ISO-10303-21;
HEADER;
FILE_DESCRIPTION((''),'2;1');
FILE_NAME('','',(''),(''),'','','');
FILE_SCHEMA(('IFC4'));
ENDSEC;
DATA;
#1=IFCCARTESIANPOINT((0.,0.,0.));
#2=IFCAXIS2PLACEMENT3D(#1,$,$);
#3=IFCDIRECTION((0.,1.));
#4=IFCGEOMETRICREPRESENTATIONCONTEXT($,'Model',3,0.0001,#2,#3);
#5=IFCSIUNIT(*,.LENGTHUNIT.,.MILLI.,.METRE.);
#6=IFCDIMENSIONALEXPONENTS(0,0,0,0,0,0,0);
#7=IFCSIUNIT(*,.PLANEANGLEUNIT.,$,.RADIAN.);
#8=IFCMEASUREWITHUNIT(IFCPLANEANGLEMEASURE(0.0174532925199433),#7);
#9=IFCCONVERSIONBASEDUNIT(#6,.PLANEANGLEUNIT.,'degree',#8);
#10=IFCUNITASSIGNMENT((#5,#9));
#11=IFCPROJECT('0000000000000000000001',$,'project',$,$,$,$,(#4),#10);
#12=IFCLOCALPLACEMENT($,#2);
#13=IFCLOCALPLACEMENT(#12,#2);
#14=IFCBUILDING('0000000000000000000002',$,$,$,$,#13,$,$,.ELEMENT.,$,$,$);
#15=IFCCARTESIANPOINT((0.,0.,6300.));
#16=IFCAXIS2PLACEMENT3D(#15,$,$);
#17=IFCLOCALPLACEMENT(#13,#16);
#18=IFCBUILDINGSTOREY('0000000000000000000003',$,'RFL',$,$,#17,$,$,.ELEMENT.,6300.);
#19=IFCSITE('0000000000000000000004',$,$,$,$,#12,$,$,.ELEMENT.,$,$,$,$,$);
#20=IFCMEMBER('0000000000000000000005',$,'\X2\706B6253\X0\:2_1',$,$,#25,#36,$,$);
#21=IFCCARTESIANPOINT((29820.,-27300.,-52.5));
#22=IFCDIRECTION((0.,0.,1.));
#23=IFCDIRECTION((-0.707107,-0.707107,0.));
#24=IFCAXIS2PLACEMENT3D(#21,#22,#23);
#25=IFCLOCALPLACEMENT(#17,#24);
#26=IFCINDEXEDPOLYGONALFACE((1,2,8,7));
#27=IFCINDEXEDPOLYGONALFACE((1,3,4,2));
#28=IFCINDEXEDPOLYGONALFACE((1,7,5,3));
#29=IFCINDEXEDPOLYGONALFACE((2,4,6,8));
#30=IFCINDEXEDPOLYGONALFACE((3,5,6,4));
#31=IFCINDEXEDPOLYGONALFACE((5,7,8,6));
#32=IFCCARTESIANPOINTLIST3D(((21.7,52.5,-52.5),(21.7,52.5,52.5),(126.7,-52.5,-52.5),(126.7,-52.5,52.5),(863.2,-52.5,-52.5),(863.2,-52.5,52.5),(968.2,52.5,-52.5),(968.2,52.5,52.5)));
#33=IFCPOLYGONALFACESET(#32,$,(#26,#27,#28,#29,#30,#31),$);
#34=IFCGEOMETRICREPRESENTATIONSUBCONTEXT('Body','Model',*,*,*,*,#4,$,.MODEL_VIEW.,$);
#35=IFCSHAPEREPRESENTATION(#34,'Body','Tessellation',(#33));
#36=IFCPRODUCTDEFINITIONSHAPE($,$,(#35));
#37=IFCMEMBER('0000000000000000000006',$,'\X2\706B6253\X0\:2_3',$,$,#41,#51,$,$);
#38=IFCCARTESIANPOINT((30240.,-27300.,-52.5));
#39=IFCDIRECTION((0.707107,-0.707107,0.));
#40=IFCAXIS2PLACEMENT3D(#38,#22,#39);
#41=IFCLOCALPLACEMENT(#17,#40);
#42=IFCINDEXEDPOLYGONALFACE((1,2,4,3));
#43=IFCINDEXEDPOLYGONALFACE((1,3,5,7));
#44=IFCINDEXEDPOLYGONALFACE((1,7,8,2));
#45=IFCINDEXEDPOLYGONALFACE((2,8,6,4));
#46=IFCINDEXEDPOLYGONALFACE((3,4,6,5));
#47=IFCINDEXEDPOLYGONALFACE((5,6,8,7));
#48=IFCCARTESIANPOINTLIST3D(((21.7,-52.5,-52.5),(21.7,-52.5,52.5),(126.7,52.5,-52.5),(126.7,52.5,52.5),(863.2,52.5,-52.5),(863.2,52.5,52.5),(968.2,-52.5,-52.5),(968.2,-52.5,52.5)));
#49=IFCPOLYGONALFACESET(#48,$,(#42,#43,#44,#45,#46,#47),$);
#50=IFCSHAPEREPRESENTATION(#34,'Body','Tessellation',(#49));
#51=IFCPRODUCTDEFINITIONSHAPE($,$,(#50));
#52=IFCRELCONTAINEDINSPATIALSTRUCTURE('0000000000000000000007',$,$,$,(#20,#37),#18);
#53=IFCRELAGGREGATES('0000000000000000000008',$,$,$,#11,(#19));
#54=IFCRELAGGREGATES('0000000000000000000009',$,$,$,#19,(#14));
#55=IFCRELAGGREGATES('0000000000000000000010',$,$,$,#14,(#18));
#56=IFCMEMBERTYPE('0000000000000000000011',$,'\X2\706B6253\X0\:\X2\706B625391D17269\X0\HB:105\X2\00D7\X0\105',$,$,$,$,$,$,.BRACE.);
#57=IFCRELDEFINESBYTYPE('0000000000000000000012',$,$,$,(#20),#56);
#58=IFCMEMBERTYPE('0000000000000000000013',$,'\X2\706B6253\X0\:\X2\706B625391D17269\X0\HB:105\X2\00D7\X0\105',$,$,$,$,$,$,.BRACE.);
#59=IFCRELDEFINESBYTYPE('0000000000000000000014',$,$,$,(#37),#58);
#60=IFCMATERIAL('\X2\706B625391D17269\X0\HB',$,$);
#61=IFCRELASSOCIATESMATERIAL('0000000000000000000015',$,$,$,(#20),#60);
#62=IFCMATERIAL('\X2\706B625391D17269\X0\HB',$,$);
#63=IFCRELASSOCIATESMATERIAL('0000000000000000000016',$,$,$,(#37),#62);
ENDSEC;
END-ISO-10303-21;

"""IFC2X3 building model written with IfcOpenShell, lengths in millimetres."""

from ifc_helpers import new_model, entity, si_unit, converted_unit, direction, frame, origin, place, context, subcontext, project, spatial, polyline, outline, extrude, material, type_object, element, save


model = new_model("IFC2X3")

# Units and contexts
model_context = context("Model", 3, precision=0.0001, world=origin(), true_north=direction((0.0, 1.0)))
body_context = subcontext(model_context, "Body", "Model", "MODEL_VIEW")
ifc_project = project(units=[si_unit("LENGTHUNIT", "METRE", prefix="MILLI"), converted_unit("PLANEANGLEUNIT", "degree", entity("IfcPlaneAngleMeasure", 0.0174532925199433), si_unit("PLANEANGLEUNIT", "RADIAN"), dimensions=[0, 0, 0, 0, 0, 0, 0])], contexts=[model_context])

# Site, building, storey
site_placement = place(None, origin())
site = spatial("IfcSite", under=ifc_project, at=site_placement, CompositionType="ELEMENT")
building_placement = place(site_placement, origin())
building = spatial("IfcBuilding", under=site, at=building_placement, CompositionType="ELEMENT")
storey_placement = place(building_placement, frame((0.0, 0.0, 6300.0)))
storey = spatial("IfcBuildingStorey", under=building, at=storey_placement, Name="RFL", CompositionType="ELEMENT", Elevation=6300.0)

# Members
ifc_material_1 = material(Name="火打金物HB")
member_type_1 = type_object("IfcMemberType", Name="火打:火打金物HB:105×105", PredefinedType="BRACE")
member_1_placement = place(storey_placement, frame((29820.0, -27300.0, -52.5), z_axis=(0.0, 0.0, 1.0), x_axis=(-0.707107, -0.707107, 0.0)))
element("IfcMember", 1, at=member_1_placement, inside=storey, type_object=member_type_1, material=ifc_material_1, Name="火打:2_1", context=body_context, shape_type="SweptSolid", body=[
    extrude(outline(polyline([(126.7, -52.5, 0.0), (21.7, 52.5, 0.0), (968.2, 52.5, 0.0), (863.2, -52.5, 0.0), (126.7, -52.5, 0.0)])), frame((0.0, 0.0, -52.5), z_axis=(0.0, 0.0, 1.0), x_axis=(1.0, 0.0, 0.0)), (0.0, 0.0, 1.0), 105.0),
])
ifc_material_2 = material(Name="火打金物HB")
member_type_2 = type_object("IfcMemberType", Name="火打:火打金物HB:105×105", PredefinedType="BRACE")
member_2_placement = place(storey_placement, frame((30240.0, -27300.0, -52.5), z_axis=(0.0, 0.0, 1.0), x_axis=(0.707107, -0.707107, 0.0)))
element("IfcMember", 2, at=member_2_placement, inside=storey, type_object=member_type_2, material=ifc_material_2, Name="火打:2_3", context=body_context, shape_type="SweptSolid", body=[
    extrude(outline(polyline([(21.7, -52.5, 0.0), (126.7, 52.5, 0.0), (863.2, 52.5, 0.0), (968.2, -52.5, 0.0), (21.7, -52.5, 0.0)])), frame((0.0, 0.0, -52.5), z_axis=(0.0, 0.0, 1.0), x_axis=(1.0, 0.0, 0.0)), (0.0, 0.0, 1.0), 105.0),
])

save(model, "model.ifc")
